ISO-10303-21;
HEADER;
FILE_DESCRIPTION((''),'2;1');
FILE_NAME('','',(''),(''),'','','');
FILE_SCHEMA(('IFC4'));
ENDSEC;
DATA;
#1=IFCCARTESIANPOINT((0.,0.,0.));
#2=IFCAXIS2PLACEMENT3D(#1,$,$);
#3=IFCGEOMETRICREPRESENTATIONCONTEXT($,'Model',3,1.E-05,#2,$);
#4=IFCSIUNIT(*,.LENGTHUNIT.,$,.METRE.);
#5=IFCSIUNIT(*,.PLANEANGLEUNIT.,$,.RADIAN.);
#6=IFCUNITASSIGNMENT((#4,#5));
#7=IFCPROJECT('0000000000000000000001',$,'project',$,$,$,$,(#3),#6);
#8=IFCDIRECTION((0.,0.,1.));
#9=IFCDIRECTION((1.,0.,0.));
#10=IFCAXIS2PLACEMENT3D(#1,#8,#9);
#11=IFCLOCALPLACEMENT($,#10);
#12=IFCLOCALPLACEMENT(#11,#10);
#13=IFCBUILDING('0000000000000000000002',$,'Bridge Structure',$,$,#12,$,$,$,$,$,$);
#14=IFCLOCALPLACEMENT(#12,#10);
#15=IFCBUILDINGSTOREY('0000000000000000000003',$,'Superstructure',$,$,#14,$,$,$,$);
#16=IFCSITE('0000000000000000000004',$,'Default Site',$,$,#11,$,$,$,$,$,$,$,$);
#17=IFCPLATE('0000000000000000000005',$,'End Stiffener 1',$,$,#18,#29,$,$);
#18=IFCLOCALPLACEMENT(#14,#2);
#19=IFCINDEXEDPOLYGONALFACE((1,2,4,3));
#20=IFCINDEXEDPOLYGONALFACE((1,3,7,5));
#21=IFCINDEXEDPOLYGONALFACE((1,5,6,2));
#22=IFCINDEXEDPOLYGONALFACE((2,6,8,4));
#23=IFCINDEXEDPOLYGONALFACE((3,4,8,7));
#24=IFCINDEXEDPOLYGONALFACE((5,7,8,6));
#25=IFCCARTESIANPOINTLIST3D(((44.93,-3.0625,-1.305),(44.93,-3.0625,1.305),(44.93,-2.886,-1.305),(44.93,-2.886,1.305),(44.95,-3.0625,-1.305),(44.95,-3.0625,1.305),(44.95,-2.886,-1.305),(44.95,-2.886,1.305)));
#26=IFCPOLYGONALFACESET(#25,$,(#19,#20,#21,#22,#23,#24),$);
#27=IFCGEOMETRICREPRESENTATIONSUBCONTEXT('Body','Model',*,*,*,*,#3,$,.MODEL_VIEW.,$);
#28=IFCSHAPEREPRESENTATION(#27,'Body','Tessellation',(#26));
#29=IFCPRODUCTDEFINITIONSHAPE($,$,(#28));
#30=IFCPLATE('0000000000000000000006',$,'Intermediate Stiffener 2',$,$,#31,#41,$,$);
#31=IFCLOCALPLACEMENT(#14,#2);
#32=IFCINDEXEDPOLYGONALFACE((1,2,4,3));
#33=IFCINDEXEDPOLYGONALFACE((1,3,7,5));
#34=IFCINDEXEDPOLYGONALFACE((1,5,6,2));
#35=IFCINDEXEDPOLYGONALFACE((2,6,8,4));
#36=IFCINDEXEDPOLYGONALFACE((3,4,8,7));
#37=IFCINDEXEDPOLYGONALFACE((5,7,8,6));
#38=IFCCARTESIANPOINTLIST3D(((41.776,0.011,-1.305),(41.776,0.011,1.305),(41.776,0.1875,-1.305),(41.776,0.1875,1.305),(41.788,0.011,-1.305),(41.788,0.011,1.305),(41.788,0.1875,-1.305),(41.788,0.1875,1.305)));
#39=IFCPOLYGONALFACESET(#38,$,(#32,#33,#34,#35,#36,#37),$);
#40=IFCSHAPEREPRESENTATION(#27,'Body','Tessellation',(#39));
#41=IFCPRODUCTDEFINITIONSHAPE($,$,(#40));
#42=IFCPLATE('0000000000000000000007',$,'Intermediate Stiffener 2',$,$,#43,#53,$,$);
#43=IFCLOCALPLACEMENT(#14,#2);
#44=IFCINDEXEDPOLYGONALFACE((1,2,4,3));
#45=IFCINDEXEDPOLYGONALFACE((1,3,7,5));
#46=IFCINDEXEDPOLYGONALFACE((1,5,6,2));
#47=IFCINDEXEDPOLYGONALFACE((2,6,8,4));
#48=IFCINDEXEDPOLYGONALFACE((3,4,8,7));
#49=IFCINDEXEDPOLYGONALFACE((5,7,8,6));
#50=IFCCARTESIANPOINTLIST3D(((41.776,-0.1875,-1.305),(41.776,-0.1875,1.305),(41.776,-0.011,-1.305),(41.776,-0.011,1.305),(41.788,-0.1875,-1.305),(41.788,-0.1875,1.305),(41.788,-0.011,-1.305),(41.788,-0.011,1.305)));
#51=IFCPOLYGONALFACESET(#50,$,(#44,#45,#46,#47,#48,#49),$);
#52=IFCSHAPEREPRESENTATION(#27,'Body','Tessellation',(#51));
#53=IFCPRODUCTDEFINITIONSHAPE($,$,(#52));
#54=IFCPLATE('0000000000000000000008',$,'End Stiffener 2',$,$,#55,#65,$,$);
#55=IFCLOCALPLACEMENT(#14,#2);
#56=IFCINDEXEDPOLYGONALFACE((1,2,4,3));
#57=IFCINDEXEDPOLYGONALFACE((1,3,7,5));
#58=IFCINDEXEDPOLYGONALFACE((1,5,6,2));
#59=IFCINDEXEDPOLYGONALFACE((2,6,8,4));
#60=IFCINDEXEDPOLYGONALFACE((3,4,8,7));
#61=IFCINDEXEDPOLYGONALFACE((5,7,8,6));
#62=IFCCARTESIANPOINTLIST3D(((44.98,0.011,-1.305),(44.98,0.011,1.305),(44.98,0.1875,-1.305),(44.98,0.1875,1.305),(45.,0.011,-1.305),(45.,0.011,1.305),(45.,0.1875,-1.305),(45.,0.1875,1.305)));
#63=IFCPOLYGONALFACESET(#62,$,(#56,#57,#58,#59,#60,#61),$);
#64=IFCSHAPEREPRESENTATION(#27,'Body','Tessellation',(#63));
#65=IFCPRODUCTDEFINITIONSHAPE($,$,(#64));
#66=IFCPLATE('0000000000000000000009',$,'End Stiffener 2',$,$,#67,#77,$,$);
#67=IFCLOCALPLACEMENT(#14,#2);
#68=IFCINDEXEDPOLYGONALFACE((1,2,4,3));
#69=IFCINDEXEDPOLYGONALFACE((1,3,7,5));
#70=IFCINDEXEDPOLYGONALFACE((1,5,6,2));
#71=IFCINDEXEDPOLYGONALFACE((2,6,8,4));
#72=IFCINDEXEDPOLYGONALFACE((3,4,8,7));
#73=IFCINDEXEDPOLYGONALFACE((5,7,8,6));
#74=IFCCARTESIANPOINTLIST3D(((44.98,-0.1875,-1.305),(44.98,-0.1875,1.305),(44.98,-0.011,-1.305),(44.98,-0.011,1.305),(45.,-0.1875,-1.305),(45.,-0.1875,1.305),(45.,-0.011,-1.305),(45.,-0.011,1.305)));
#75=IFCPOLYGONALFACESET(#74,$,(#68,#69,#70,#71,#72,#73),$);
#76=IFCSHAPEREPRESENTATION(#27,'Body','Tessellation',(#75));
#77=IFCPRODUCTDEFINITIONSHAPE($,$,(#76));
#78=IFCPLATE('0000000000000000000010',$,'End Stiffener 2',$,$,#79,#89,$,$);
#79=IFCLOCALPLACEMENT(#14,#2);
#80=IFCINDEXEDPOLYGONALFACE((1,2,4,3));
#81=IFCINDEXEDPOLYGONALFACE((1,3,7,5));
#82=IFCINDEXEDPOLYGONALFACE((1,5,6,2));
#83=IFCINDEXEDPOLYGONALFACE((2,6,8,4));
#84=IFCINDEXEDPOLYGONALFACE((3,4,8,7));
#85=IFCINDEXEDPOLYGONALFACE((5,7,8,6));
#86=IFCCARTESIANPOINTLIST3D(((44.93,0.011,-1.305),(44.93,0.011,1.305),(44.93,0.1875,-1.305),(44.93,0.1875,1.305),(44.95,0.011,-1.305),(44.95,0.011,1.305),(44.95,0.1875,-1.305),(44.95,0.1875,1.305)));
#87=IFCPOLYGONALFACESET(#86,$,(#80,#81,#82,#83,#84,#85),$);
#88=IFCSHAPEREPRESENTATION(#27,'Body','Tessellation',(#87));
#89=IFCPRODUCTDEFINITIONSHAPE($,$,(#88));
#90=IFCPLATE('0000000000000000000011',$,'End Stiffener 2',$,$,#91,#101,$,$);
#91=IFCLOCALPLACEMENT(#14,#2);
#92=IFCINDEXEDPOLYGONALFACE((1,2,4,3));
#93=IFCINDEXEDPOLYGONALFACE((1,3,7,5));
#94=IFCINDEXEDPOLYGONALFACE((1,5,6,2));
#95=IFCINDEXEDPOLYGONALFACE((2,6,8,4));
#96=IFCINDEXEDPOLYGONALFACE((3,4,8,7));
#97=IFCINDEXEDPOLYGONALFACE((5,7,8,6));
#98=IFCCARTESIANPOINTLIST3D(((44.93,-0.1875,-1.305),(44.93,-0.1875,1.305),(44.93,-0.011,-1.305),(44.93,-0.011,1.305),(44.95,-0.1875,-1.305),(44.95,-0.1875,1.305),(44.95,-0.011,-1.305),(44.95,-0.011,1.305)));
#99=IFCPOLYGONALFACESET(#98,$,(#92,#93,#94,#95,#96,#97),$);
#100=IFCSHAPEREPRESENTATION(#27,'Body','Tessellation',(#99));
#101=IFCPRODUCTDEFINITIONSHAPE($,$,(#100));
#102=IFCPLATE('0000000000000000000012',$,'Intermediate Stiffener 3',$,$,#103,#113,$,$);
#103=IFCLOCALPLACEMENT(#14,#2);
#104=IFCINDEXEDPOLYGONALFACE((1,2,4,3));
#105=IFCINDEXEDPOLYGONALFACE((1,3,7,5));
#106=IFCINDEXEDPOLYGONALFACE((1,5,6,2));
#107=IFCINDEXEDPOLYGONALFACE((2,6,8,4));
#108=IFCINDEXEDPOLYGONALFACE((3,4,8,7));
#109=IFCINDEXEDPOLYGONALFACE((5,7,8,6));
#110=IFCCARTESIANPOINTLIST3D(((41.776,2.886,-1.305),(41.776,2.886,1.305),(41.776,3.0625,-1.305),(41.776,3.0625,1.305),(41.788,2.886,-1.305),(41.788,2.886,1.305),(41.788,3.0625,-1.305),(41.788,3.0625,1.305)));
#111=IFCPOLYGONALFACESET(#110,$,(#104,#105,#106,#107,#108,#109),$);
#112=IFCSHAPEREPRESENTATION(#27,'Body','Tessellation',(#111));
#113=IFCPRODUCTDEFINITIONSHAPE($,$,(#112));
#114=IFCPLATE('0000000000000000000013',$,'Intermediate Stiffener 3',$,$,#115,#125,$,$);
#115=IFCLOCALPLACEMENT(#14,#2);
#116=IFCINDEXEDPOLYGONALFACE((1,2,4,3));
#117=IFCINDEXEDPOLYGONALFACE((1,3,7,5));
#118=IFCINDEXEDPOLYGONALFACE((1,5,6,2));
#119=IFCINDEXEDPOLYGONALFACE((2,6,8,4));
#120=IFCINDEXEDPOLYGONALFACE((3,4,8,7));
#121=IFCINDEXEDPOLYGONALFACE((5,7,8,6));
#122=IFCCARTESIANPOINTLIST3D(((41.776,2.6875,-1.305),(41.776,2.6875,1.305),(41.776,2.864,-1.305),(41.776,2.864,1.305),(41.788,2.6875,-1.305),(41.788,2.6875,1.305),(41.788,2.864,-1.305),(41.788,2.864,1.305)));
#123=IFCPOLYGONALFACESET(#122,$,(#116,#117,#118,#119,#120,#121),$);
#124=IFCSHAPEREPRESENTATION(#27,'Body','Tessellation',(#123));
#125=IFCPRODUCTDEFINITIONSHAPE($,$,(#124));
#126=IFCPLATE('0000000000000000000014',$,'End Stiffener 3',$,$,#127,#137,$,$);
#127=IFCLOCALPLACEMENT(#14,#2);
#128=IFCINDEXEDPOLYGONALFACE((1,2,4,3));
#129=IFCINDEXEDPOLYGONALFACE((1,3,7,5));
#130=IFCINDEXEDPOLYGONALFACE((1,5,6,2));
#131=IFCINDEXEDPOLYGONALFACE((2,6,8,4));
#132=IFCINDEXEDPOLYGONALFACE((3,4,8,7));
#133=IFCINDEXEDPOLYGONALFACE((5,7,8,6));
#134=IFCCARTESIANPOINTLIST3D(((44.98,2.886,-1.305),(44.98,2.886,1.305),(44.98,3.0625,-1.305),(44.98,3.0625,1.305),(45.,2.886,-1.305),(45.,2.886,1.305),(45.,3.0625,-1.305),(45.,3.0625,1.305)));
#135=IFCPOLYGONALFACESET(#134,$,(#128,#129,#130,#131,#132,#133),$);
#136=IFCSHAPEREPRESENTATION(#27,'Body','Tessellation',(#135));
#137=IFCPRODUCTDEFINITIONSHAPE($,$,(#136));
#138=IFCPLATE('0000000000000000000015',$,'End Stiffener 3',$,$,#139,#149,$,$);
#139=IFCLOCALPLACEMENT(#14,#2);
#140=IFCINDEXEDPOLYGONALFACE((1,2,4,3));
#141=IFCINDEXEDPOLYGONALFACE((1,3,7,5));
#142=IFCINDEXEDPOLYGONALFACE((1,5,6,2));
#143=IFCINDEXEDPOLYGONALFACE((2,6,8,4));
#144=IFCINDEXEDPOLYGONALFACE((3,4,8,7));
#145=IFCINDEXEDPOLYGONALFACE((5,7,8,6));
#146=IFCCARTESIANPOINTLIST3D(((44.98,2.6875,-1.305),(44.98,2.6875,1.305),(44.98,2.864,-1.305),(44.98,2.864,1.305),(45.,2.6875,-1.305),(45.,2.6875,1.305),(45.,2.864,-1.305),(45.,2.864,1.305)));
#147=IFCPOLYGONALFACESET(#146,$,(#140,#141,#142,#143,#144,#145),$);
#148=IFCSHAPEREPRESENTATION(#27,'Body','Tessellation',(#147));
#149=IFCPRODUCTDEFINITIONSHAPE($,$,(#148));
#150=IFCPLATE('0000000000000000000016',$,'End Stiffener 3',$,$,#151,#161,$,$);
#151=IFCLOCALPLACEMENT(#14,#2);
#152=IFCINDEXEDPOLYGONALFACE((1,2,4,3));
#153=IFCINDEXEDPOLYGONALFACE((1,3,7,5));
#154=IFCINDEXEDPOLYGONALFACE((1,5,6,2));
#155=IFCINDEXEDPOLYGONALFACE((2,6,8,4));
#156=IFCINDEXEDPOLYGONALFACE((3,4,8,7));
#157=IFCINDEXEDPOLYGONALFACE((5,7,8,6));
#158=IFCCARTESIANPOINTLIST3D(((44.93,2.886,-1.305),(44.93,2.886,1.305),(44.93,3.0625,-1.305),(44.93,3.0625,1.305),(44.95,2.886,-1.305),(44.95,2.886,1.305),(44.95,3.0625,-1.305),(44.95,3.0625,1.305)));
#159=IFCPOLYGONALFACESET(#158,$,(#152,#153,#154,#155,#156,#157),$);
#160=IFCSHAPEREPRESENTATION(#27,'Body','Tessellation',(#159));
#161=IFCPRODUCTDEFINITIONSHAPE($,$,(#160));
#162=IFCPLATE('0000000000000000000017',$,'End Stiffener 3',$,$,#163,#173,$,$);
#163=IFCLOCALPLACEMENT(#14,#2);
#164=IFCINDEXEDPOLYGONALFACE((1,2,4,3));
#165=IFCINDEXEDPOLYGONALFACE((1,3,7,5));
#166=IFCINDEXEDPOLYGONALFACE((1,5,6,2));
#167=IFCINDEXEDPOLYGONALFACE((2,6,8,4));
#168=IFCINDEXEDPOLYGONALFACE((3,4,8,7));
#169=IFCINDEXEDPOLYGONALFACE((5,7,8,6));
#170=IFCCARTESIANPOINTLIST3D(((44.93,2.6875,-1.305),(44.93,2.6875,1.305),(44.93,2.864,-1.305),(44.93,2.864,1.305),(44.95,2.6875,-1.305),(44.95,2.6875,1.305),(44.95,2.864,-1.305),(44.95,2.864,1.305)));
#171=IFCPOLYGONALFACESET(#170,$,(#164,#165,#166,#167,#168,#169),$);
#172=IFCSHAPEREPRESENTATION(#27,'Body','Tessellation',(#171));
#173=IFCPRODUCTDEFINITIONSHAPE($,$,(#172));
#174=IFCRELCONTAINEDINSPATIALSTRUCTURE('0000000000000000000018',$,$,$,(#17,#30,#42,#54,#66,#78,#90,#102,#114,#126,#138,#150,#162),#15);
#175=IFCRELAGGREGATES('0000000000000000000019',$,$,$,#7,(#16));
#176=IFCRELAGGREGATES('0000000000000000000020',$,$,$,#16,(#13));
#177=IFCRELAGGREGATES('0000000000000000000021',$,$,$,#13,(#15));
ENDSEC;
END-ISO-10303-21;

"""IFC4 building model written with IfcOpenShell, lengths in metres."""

from ifc_helpers import new_model, si_unit, frame, origin, origin_with_axes, origin_2d_with_axis, place, context, subcontext, project, spatial, rectangle, extrude, element, save


model = new_model("IFC4")

# Units and contexts
model_context = context("Model", 3, precision=1e-05, world=origin())
body_context = subcontext(model_context, "Body", "Model", "MODEL_VIEW")
ifc_project = project(units=[si_unit("LENGTHUNIT", "METRE"), si_unit("PLANEANGLEUNIT", "RADIAN")], contexts=[model_context])

# Site, building, storey
site_placement = place(None, origin_with_axes())
site = spatial("IfcSite", under=ifc_project, at=site_placement, Name="Default Site")
building_placement = place(site_placement, origin_with_axes())
building = spatial("IfcBuilding", under=site, at=building_placement, Name="Bridge Structure")
storey_placement = place(building_placement, origin_with_axes())
storey = spatial("IfcBuildingStorey", under=building, at=storey_placement, Name="Superstructure")

# Plates
for number, where, z_axis, x_axis, name in (
    (1, (44.94, -2.9743, -1.305), (0.0, 0.0, 1.0), (1.0, 0.0, 0.0), "End Stiffener 1"),
):
    element("IfcPlate", number, at=place(storey_placement, frame(where, z_axis=z_axis, x_axis=x_axis)), inside=storey, Name=name, context=body_context, shape_type="SweptSolid", body=[
        extrude(rectangle(XDim=0.02, YDim=0.1765, at=origin_2d_with_axis()), origin_with_axes(), (0.0, 0.0, 1.0), 2.61),
    ])
for number, where, z_axis, x_axis, name in (
    (2, (41.782, 0.0993, -1.305), (0.0, 0.0, 1.0), (1.0, 0.0, 0.0), "Intermediate Stiffener 2"),
    (3, (41.782, -0.0993, -1.305), (0.0, 0.0, 1.0), (1.0, 0.0, 0.0), "Intermediate Stiffener 2"),
):
    element("IfcPlate", number, at=place(storey_placement, frame(where, z_axis=z_axis, x_axis=x_axis)), inside=storey, Name=name, context=body_context, shape_type="SweptSolid", body=[
        extrude(rectangle(XDim=0.012, YDim=0.1765, at=origin_2d_with_axis()), origin_with_axes(), (0.0, 0.0, 1.0), 2.61),
    ])
for number, where, z_axis, x_axis, name in (
    (4, (44.99, 0.0993, -1.305), (0.0, 0.0, 1.0), (1.0, 0.0, 0.0), "End Stiffener 2"),
    (5, (44.99, -0.0993, -1.305), (0.0, 0.0, 1.0), (1.0, 0.0, 0.0), "End Stiffener 2"),
    (6, (44.94, 0.0993, -1.305), (0.0, 0.0, 1.0), (1.0, 0.0, 0.0), "End Stiffener 2"),
    (7, (44.94, -0.0993, -1.305), (0.0, 0.0, 1.0), (1.0, 0.0, 0.0), "End Stiffener 2"),
):
    element("IfcPlate", number, at=place(storey_placement, frame(where, z_axis=z_axis, x_axis=x_axis)), inside=storey, Name=name, context=body_context, shape_type="SweptSolid", body=[
        extrude(rectangle(XDim=0.02, YDim=0.1765, at=origin_2d_with_axis()), origin_with_axes(), (0.0, 0.0, 1.0), 2.61),
    ])
for number, where, z_axis, x_axis, name in (
    (8, (41.782, 2.9743, -1.305), (0.0, 0.0, 1.0), (1.0, 0.0, 0.0), "Intermediate Stiffener 3"),
    (9, (41.782, 2.7757, -1.305), (0.0, 0.0, 1.0), (1.0, 0.0, 0.0), "Intermediate Stiffener 3"),
):
    element("IfcPlate", number, at=place(storey_placement, frame(where, z_axis=z_axis, x_axis=x_axis)), inside=storey, Name=name, context=body_context, shape_type="SweptSolid", body=[
        extrude(rectangle(XDim=0.012, YDim=0.1765, at=origin_2d_with_axis()), origin_with_axes(), (0.0, 0.0, 1.0), 2.61),
    ])
for number, where, z_axis, x_axis, name in (
    (10, (44.99, 2.9743, -1.305), (0.0, 0.0, 1.0), (1.0, 0.0, 0.0), "End Stiffener 3"),
    (11, (44.99, 2.7757, -1.305), (0.0, 0.0, 1.0), (1.0, 0.0, 0.0), "End Stiffener 3"),
    (12, (44.94, 2.9743, -1.305), (0.0, 0.0, 1.0), (1.0, 0.0, 0.0), "End Stiffener 3"),
    (13, (44.94, 2.7757, -1.305), (0.0, 0.0, 1.0), (1.0, 0.0, 0.0), "End Stiffener 3"),
):
    element("IfcPlate", number, at=place(storey_placement, frame(where, z_axis=z_axis, x_axis=x_axis)), inside=storey, Name=name, context=body_context, shape_type="SweptSolid", body=[
        extrude(rectangle(XDim=0.02, YDim=0.1765, at=origin_2d_with_axis()), origin_with_axes(), (0.0, 0.0, 1.0), 2.61),
    ])

save(model, "model.ifc")
